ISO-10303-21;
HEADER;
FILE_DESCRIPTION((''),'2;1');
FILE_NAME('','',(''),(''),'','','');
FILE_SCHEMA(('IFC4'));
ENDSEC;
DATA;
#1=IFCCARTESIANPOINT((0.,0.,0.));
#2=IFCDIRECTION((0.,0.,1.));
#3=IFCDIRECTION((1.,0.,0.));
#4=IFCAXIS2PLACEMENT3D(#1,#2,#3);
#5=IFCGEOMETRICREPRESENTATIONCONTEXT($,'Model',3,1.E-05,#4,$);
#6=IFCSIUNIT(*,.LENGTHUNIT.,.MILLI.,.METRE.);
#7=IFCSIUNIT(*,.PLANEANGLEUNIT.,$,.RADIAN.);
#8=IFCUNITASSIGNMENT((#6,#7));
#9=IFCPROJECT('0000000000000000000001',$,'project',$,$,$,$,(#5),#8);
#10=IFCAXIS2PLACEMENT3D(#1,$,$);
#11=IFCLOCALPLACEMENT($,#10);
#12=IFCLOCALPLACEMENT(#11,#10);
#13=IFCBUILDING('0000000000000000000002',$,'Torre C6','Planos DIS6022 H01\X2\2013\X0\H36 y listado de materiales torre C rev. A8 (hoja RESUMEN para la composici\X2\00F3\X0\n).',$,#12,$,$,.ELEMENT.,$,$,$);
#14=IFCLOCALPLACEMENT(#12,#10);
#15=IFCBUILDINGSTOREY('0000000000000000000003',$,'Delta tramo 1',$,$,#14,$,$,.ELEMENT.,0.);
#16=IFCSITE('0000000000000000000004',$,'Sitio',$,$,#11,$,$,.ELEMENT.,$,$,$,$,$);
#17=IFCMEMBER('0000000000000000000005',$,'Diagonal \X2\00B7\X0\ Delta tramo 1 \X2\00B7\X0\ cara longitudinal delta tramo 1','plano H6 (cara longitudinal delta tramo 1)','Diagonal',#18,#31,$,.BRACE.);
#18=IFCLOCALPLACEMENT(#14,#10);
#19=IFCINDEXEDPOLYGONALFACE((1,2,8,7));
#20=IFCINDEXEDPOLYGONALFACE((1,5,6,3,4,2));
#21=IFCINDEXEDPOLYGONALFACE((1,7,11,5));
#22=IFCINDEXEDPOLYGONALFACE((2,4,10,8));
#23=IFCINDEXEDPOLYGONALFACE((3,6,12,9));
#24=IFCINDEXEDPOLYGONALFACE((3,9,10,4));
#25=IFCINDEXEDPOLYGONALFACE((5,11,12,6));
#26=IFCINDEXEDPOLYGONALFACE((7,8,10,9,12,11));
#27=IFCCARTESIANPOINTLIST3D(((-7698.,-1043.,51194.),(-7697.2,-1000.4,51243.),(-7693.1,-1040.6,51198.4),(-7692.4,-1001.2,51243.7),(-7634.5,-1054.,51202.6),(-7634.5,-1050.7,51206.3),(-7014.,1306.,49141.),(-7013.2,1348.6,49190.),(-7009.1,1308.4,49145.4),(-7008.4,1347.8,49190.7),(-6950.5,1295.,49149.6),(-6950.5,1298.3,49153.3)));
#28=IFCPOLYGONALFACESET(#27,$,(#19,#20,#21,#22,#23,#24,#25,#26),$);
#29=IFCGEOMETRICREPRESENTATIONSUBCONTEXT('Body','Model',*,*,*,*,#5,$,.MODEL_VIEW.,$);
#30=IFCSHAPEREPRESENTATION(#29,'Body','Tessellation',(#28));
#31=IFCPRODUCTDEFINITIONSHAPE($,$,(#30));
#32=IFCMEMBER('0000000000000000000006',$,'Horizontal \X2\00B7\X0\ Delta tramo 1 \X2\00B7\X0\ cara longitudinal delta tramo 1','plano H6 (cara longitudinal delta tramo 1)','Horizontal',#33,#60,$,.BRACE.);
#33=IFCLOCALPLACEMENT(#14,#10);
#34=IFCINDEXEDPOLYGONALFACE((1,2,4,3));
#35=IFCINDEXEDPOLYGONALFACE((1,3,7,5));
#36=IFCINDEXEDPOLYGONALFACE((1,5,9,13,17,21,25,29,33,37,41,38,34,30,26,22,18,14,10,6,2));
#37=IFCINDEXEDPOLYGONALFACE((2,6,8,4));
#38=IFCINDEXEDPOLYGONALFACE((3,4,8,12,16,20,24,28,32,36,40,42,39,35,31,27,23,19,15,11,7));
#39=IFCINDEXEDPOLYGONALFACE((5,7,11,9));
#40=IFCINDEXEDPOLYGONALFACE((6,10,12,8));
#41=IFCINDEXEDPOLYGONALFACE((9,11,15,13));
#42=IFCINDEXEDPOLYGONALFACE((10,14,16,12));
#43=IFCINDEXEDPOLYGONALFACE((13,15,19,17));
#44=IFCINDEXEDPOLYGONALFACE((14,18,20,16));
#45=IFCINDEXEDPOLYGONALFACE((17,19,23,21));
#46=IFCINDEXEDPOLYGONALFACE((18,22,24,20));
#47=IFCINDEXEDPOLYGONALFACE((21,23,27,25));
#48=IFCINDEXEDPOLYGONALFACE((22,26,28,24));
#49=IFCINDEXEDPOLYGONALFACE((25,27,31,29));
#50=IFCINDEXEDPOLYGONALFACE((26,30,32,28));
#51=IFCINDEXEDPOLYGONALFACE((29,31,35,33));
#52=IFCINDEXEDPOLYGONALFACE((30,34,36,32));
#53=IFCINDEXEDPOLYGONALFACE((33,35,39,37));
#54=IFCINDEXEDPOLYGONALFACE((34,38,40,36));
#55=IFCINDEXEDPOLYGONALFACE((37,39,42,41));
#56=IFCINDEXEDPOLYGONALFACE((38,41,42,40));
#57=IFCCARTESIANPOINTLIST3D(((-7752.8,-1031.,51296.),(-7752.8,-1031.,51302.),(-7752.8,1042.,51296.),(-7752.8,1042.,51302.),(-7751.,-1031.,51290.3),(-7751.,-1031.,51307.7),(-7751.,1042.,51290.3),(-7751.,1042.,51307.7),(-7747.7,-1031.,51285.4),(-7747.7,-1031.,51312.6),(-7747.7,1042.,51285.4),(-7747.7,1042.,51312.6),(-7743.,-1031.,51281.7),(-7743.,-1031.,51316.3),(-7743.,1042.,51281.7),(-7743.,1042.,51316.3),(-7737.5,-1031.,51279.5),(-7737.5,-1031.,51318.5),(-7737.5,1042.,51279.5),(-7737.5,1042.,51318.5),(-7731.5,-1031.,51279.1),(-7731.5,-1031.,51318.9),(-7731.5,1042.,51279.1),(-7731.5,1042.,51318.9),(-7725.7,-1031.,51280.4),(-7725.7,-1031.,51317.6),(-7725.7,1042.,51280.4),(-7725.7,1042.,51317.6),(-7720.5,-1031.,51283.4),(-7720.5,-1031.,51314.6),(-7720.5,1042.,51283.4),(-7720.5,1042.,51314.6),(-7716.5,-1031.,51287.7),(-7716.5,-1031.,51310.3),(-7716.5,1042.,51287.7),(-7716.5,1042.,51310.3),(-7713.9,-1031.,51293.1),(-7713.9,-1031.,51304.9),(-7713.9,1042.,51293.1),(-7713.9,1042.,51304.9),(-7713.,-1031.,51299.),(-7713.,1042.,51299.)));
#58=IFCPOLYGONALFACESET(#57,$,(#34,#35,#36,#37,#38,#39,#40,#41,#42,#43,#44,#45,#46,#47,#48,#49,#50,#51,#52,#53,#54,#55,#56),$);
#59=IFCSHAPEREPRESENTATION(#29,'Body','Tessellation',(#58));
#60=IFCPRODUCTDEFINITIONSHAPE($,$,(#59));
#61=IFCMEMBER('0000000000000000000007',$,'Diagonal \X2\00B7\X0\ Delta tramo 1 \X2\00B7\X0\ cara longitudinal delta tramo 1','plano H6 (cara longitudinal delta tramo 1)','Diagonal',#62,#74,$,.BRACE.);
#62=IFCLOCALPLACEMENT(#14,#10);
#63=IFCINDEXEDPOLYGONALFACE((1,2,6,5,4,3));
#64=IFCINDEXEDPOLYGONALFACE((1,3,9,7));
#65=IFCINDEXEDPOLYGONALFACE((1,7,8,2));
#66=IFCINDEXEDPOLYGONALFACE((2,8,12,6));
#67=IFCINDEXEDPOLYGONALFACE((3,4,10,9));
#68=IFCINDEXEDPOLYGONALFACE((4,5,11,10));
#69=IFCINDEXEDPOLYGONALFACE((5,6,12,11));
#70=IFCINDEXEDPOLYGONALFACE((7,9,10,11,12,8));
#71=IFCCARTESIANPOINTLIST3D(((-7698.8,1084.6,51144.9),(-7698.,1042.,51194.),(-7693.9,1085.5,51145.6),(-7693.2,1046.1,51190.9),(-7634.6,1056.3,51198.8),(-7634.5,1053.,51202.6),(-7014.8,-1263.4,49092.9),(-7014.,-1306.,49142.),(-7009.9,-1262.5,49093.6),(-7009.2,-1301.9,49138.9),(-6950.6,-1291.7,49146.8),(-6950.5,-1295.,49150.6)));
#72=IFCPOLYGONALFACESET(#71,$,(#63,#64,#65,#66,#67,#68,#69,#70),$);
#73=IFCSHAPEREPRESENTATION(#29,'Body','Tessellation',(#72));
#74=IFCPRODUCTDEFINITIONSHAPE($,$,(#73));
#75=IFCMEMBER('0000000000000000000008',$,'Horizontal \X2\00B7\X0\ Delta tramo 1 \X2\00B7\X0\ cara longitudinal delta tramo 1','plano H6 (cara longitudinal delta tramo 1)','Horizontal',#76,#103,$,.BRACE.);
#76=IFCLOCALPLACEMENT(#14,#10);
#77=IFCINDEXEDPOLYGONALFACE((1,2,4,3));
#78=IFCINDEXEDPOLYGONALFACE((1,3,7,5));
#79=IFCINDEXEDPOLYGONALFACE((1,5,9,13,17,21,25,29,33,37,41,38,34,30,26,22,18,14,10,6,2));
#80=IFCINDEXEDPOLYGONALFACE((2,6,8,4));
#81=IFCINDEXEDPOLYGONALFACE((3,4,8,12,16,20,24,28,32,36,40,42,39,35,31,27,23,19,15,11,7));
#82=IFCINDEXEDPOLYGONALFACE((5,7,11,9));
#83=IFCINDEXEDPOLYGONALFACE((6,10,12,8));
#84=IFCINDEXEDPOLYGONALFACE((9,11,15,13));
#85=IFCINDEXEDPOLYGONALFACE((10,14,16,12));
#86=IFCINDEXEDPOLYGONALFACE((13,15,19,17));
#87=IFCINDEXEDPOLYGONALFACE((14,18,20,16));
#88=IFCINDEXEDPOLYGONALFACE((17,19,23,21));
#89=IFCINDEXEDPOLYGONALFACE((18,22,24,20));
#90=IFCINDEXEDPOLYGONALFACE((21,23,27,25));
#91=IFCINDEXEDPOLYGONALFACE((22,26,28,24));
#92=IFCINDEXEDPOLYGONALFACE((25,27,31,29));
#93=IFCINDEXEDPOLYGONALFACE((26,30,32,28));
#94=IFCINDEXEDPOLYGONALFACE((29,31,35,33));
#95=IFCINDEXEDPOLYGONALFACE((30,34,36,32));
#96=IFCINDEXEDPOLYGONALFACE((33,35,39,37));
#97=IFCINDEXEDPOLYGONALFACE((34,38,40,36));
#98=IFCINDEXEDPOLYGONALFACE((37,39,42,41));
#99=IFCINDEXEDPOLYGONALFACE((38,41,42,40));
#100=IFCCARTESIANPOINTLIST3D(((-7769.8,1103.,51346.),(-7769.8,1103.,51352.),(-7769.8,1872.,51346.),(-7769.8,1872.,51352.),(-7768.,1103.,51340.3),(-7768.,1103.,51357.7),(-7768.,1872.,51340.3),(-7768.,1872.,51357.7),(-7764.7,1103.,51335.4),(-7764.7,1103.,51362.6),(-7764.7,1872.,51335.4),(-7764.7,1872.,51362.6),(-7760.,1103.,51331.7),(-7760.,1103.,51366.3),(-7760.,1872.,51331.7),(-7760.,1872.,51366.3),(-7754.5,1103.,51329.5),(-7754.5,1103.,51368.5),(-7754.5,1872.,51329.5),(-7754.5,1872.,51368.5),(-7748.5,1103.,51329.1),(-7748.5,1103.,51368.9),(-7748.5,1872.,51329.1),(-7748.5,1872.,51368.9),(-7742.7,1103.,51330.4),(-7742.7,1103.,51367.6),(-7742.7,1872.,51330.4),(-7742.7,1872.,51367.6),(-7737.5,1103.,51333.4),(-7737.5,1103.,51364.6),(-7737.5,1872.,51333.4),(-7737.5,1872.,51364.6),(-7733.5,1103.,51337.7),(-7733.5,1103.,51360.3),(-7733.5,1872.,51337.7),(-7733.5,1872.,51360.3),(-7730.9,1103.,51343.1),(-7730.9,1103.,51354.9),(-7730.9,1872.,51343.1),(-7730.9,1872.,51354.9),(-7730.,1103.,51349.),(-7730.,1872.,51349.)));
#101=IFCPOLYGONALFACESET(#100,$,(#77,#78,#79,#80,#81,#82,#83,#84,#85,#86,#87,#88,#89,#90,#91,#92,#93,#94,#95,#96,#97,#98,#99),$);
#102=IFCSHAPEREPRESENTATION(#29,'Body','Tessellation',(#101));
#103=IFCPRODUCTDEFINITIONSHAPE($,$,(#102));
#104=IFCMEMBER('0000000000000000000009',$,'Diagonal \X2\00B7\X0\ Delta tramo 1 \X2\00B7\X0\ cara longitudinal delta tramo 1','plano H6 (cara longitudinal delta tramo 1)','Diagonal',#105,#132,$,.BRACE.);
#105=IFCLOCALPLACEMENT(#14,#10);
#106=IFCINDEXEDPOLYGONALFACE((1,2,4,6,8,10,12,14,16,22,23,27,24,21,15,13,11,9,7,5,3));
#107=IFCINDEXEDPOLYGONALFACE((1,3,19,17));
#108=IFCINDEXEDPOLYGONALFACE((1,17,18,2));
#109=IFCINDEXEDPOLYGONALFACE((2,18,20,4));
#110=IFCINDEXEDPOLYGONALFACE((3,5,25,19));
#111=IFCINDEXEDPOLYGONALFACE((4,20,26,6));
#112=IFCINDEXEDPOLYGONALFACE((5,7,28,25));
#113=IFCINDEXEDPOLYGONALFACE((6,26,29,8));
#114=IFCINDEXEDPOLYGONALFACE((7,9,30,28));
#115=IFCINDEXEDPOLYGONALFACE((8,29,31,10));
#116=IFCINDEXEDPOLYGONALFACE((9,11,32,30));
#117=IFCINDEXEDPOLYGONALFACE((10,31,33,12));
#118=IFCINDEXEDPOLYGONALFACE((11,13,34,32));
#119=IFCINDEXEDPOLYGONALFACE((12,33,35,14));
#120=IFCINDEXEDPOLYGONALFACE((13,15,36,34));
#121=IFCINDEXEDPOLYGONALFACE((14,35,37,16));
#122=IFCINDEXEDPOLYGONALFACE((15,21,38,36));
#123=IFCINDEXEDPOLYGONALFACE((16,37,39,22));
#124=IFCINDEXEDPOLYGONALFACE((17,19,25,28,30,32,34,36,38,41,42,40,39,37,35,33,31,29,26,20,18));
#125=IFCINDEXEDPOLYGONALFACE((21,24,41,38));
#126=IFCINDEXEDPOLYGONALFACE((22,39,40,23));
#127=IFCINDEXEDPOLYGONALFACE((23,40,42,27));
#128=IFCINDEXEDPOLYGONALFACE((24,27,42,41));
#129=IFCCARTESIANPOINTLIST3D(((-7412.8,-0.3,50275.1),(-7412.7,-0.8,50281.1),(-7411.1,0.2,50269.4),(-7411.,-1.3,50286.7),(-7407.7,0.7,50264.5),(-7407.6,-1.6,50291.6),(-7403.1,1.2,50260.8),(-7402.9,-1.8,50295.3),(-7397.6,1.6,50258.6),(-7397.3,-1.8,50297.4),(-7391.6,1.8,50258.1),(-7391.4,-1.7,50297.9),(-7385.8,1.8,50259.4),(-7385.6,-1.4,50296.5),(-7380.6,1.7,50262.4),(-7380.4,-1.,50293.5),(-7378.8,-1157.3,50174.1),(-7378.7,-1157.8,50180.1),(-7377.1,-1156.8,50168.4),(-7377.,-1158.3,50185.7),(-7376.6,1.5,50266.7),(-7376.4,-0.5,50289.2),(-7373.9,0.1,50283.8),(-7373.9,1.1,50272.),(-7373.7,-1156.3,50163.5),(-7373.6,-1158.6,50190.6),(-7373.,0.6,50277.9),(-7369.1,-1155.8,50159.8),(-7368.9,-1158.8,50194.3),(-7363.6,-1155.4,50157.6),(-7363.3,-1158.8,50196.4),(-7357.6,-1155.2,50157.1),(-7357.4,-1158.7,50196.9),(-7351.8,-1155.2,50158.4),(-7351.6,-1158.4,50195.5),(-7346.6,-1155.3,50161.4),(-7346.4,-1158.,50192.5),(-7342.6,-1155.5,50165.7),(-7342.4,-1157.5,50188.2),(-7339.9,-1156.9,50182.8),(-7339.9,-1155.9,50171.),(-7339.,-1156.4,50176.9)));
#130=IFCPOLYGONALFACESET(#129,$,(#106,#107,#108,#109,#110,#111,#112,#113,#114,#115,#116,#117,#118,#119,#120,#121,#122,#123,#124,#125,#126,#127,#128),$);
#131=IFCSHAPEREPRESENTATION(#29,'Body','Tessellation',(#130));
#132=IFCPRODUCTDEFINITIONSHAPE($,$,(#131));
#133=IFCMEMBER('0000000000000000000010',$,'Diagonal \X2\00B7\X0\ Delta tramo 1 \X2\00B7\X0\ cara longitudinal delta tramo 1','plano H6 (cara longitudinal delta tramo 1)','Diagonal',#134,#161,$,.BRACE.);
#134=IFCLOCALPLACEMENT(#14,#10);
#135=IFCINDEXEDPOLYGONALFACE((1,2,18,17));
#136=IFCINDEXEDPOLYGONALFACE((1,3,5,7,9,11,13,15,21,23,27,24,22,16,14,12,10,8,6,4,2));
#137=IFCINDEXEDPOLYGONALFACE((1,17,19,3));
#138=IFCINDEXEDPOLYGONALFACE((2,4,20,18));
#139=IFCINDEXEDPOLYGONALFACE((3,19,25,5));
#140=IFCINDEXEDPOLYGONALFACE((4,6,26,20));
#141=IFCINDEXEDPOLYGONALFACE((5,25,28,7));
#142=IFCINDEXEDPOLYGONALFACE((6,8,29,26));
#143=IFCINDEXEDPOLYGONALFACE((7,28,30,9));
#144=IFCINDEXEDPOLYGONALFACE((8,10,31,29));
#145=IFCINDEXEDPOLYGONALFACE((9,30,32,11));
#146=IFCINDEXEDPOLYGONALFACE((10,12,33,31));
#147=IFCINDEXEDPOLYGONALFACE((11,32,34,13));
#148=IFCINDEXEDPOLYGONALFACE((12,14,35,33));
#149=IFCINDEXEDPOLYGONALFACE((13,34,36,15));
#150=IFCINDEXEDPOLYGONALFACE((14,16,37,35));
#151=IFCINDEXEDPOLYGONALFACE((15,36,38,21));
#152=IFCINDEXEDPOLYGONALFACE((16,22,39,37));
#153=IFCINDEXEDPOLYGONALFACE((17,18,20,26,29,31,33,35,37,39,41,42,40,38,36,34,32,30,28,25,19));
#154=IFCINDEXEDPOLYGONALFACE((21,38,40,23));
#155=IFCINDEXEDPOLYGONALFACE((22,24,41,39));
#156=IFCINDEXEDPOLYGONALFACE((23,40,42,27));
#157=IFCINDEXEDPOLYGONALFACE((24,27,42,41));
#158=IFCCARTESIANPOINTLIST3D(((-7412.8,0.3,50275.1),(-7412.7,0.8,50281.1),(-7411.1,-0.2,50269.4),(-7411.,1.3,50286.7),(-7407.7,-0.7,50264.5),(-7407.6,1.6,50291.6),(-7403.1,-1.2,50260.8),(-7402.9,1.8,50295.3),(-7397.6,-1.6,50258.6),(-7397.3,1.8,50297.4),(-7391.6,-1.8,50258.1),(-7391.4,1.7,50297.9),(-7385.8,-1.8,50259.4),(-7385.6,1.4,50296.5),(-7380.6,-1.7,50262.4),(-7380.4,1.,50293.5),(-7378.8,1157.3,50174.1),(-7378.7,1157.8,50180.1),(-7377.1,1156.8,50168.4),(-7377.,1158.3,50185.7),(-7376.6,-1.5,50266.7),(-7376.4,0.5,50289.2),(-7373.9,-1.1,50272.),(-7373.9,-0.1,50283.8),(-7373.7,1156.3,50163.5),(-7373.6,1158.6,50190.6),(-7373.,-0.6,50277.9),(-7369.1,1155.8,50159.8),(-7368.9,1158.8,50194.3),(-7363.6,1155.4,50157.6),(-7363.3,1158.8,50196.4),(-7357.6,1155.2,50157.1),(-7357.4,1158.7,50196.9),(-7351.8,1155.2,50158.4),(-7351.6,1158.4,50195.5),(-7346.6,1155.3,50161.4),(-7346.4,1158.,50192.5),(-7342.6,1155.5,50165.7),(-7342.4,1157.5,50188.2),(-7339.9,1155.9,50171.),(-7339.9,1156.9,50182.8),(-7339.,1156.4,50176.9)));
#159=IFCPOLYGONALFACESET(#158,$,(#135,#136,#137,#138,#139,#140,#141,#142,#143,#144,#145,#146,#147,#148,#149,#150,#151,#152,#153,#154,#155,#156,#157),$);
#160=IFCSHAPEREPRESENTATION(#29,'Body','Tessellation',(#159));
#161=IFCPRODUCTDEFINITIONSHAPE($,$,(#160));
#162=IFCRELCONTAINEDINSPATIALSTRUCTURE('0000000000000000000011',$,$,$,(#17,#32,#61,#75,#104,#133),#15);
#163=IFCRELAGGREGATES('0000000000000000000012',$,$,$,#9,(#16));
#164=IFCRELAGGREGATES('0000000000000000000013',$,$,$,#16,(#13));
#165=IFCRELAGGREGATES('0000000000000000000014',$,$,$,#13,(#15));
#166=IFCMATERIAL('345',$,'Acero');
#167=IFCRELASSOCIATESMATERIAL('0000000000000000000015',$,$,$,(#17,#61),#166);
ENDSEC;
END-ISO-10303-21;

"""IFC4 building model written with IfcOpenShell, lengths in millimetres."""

from ifc_helpers import new_model, si_unit, frame, frame_2d, origin, origin_with_axes, place, context, subcontext, project, spatial, circle, l_section, extrude, material, element, save


model = new_model("IFC4")

# Units and contexts
model_context = context("Model", 3, precision=1e-05, world=origin_with_axes())
body_context = subcontext(model_context, "Body", "Model", "MODEL_VIEW")
ifc_project = project(units=[si_unit("LENGTHUNIT", "METRE", prefix="MILLI"), si_unit("PLANEANGLEUNIT", "RADIAN")], contexts=[model_context])

# Site, building, storey
site_placement = place(None, origin())
site = spatial("IfcSite", under=ifc_project, at=site_placement, Name="Sitio", CompositionType="ELEMENT")
building_placement = place(site_placement, origin())
building = spatial("IfcBuilding", under=site, at=building_placement, Name="Torre C6", Description="Planos DIS6022 H01–H36 y listado de materiales torre C rev. A8 (hoja RESUMEN para la composición).", CompositionType="ELEMENT")
storey_placement = place(building_placement, origin())
storey = spatial("IfcBuildingStorey", under=building, at=storey_placement, Name="Delta tramo 1", CompositionType="ELEMENT", Elevation=0.0)

# Members
ifc_material = material(Name="345", Category="Acero")
member_1_placement = place(storey_placement, frame((-7014.0, 1306.0, 49141.0), z_axis=(-0.214164, -0.735484, 0.642805), x_axis=(0.976727, -0.169145, 0.131884)))
element("IfcMember", 1, at=member_1_placement, inside=storey, material=ifc_material, Name="Diagonal · Delta tramo 1 · cara longitudinal delta tramo 1", Description="plano H6 (cara longitudinal delta tramo 1)", ObjectType="Diagonal", PredefinedType="BRACE", context=body_context, shape_type="SweptSolid", body=[
    extrude(l_section(Depth=65.0, Width=65.0, Thickness=5.0, at=frame_2d((32.5, 32.5))), None, (0.0, 0.0, 1.0), 3193.8),
])
member_2_placement = place(storey_placement, frame((-7733.0, -1031.0, 51299.0), z_axis=(0.0, 1.0, 0.0), x_axis=(1.0, 0.0, 0.0)))
element("IfcMember", 2, at=member_2_placement, inside=storey, Name="Horizontal · Delta tramo 1 · cara longitudinal delta tramo 1", Description="plano H6 (cara longitudinal delta tramo 1)", ObjectType="Horizontal", PredefinedType="BRACE", context=body_context, shape_type="SweptSolid", body=[
    extrude(circle(Radius=20.0), None, (0.0, 0.0, 1.0), 2073.0),
])
member_3_placement = place(storey_placement, frame((-7014.0, -1306.0, 49142.0), z_axis=(-0.214256, 0.735488, 0.642769), x_axis=(0.976707, 0.169249, 0.131906)))
element("IfcMember", 3, at=member_3_placement, inside=storey, material=ifc_material, Name="Diagonal · Delta tramo 1 · cara longitudinal delta tramo 1", Description="plano H6 (cara longitudinal delta tramo 1)", ObjectType="Diagonal", PredefinedType="BRACE", context=body_context, shape_type="SweptSolid", body=[
    extrude(l_section(Depth=65.0, Width=65.0, Thickness=5.0, at=frame_2d((32.5, 32.5))), None, (0.0, 0.0, 1.0), 3192.4),
])
member_4_placement = place(storey_placement, frame((-7750.0, 1103.0, 51349.0), z_axis=(0.0, 1.0, 0.0), x_axis=(1.0, 0.0, 0.0)))
element("IfcMember", 4, at=member_4_placement, inside=storey, Name="Horizontal · Delta tramo 1 · cara longitudinal delta tramo 1", Description="plano H6 (cara longitudinal delta tramo 1)", ObjectType="Horizontal", PredefinedType="BRACE", context=body_context, shape_type="SweptSolid", body=[
    extrude(circle(Radius=20.0), None, (0.0, 0.0, 1.0), 769.0),
])
for number, where, z_axis, x_axis, name in (
    (5, (-7359.0, -1157.0, 50177.0), (-0.029262, 0.995785, 0.086927), (0.999549, 0.029743, -0.004237), "Diagonal · Delta tramo 1 · cara longitudinal delta tramo 1"),
    (6, (-7359.0, 1157.0, 50177.0), (-0.029262, -0.995785, 0.086927), (0.999549, -0.029743, -0.004237), "Diagonal · Delta tramo 1 · cara longitudinal delta tramo 1"),
):
    element("IfcMember", number, at=place(storey_placement, frame(where, z_axis=z_axis, x_axis=x_axis)), inside=storey, Name=name, Description="plano H6 (cara longitudinal delta tramo 1)", ObjectType="Diagonal", PredefinedType="BRACE", context=body_context, shape_type="SweptSolid", body=[
        extrude(circle(Radius=20.0), None, (0.0, 0.0, 1.0), 1161.9),
    ])

save(model, "model.ifc")
